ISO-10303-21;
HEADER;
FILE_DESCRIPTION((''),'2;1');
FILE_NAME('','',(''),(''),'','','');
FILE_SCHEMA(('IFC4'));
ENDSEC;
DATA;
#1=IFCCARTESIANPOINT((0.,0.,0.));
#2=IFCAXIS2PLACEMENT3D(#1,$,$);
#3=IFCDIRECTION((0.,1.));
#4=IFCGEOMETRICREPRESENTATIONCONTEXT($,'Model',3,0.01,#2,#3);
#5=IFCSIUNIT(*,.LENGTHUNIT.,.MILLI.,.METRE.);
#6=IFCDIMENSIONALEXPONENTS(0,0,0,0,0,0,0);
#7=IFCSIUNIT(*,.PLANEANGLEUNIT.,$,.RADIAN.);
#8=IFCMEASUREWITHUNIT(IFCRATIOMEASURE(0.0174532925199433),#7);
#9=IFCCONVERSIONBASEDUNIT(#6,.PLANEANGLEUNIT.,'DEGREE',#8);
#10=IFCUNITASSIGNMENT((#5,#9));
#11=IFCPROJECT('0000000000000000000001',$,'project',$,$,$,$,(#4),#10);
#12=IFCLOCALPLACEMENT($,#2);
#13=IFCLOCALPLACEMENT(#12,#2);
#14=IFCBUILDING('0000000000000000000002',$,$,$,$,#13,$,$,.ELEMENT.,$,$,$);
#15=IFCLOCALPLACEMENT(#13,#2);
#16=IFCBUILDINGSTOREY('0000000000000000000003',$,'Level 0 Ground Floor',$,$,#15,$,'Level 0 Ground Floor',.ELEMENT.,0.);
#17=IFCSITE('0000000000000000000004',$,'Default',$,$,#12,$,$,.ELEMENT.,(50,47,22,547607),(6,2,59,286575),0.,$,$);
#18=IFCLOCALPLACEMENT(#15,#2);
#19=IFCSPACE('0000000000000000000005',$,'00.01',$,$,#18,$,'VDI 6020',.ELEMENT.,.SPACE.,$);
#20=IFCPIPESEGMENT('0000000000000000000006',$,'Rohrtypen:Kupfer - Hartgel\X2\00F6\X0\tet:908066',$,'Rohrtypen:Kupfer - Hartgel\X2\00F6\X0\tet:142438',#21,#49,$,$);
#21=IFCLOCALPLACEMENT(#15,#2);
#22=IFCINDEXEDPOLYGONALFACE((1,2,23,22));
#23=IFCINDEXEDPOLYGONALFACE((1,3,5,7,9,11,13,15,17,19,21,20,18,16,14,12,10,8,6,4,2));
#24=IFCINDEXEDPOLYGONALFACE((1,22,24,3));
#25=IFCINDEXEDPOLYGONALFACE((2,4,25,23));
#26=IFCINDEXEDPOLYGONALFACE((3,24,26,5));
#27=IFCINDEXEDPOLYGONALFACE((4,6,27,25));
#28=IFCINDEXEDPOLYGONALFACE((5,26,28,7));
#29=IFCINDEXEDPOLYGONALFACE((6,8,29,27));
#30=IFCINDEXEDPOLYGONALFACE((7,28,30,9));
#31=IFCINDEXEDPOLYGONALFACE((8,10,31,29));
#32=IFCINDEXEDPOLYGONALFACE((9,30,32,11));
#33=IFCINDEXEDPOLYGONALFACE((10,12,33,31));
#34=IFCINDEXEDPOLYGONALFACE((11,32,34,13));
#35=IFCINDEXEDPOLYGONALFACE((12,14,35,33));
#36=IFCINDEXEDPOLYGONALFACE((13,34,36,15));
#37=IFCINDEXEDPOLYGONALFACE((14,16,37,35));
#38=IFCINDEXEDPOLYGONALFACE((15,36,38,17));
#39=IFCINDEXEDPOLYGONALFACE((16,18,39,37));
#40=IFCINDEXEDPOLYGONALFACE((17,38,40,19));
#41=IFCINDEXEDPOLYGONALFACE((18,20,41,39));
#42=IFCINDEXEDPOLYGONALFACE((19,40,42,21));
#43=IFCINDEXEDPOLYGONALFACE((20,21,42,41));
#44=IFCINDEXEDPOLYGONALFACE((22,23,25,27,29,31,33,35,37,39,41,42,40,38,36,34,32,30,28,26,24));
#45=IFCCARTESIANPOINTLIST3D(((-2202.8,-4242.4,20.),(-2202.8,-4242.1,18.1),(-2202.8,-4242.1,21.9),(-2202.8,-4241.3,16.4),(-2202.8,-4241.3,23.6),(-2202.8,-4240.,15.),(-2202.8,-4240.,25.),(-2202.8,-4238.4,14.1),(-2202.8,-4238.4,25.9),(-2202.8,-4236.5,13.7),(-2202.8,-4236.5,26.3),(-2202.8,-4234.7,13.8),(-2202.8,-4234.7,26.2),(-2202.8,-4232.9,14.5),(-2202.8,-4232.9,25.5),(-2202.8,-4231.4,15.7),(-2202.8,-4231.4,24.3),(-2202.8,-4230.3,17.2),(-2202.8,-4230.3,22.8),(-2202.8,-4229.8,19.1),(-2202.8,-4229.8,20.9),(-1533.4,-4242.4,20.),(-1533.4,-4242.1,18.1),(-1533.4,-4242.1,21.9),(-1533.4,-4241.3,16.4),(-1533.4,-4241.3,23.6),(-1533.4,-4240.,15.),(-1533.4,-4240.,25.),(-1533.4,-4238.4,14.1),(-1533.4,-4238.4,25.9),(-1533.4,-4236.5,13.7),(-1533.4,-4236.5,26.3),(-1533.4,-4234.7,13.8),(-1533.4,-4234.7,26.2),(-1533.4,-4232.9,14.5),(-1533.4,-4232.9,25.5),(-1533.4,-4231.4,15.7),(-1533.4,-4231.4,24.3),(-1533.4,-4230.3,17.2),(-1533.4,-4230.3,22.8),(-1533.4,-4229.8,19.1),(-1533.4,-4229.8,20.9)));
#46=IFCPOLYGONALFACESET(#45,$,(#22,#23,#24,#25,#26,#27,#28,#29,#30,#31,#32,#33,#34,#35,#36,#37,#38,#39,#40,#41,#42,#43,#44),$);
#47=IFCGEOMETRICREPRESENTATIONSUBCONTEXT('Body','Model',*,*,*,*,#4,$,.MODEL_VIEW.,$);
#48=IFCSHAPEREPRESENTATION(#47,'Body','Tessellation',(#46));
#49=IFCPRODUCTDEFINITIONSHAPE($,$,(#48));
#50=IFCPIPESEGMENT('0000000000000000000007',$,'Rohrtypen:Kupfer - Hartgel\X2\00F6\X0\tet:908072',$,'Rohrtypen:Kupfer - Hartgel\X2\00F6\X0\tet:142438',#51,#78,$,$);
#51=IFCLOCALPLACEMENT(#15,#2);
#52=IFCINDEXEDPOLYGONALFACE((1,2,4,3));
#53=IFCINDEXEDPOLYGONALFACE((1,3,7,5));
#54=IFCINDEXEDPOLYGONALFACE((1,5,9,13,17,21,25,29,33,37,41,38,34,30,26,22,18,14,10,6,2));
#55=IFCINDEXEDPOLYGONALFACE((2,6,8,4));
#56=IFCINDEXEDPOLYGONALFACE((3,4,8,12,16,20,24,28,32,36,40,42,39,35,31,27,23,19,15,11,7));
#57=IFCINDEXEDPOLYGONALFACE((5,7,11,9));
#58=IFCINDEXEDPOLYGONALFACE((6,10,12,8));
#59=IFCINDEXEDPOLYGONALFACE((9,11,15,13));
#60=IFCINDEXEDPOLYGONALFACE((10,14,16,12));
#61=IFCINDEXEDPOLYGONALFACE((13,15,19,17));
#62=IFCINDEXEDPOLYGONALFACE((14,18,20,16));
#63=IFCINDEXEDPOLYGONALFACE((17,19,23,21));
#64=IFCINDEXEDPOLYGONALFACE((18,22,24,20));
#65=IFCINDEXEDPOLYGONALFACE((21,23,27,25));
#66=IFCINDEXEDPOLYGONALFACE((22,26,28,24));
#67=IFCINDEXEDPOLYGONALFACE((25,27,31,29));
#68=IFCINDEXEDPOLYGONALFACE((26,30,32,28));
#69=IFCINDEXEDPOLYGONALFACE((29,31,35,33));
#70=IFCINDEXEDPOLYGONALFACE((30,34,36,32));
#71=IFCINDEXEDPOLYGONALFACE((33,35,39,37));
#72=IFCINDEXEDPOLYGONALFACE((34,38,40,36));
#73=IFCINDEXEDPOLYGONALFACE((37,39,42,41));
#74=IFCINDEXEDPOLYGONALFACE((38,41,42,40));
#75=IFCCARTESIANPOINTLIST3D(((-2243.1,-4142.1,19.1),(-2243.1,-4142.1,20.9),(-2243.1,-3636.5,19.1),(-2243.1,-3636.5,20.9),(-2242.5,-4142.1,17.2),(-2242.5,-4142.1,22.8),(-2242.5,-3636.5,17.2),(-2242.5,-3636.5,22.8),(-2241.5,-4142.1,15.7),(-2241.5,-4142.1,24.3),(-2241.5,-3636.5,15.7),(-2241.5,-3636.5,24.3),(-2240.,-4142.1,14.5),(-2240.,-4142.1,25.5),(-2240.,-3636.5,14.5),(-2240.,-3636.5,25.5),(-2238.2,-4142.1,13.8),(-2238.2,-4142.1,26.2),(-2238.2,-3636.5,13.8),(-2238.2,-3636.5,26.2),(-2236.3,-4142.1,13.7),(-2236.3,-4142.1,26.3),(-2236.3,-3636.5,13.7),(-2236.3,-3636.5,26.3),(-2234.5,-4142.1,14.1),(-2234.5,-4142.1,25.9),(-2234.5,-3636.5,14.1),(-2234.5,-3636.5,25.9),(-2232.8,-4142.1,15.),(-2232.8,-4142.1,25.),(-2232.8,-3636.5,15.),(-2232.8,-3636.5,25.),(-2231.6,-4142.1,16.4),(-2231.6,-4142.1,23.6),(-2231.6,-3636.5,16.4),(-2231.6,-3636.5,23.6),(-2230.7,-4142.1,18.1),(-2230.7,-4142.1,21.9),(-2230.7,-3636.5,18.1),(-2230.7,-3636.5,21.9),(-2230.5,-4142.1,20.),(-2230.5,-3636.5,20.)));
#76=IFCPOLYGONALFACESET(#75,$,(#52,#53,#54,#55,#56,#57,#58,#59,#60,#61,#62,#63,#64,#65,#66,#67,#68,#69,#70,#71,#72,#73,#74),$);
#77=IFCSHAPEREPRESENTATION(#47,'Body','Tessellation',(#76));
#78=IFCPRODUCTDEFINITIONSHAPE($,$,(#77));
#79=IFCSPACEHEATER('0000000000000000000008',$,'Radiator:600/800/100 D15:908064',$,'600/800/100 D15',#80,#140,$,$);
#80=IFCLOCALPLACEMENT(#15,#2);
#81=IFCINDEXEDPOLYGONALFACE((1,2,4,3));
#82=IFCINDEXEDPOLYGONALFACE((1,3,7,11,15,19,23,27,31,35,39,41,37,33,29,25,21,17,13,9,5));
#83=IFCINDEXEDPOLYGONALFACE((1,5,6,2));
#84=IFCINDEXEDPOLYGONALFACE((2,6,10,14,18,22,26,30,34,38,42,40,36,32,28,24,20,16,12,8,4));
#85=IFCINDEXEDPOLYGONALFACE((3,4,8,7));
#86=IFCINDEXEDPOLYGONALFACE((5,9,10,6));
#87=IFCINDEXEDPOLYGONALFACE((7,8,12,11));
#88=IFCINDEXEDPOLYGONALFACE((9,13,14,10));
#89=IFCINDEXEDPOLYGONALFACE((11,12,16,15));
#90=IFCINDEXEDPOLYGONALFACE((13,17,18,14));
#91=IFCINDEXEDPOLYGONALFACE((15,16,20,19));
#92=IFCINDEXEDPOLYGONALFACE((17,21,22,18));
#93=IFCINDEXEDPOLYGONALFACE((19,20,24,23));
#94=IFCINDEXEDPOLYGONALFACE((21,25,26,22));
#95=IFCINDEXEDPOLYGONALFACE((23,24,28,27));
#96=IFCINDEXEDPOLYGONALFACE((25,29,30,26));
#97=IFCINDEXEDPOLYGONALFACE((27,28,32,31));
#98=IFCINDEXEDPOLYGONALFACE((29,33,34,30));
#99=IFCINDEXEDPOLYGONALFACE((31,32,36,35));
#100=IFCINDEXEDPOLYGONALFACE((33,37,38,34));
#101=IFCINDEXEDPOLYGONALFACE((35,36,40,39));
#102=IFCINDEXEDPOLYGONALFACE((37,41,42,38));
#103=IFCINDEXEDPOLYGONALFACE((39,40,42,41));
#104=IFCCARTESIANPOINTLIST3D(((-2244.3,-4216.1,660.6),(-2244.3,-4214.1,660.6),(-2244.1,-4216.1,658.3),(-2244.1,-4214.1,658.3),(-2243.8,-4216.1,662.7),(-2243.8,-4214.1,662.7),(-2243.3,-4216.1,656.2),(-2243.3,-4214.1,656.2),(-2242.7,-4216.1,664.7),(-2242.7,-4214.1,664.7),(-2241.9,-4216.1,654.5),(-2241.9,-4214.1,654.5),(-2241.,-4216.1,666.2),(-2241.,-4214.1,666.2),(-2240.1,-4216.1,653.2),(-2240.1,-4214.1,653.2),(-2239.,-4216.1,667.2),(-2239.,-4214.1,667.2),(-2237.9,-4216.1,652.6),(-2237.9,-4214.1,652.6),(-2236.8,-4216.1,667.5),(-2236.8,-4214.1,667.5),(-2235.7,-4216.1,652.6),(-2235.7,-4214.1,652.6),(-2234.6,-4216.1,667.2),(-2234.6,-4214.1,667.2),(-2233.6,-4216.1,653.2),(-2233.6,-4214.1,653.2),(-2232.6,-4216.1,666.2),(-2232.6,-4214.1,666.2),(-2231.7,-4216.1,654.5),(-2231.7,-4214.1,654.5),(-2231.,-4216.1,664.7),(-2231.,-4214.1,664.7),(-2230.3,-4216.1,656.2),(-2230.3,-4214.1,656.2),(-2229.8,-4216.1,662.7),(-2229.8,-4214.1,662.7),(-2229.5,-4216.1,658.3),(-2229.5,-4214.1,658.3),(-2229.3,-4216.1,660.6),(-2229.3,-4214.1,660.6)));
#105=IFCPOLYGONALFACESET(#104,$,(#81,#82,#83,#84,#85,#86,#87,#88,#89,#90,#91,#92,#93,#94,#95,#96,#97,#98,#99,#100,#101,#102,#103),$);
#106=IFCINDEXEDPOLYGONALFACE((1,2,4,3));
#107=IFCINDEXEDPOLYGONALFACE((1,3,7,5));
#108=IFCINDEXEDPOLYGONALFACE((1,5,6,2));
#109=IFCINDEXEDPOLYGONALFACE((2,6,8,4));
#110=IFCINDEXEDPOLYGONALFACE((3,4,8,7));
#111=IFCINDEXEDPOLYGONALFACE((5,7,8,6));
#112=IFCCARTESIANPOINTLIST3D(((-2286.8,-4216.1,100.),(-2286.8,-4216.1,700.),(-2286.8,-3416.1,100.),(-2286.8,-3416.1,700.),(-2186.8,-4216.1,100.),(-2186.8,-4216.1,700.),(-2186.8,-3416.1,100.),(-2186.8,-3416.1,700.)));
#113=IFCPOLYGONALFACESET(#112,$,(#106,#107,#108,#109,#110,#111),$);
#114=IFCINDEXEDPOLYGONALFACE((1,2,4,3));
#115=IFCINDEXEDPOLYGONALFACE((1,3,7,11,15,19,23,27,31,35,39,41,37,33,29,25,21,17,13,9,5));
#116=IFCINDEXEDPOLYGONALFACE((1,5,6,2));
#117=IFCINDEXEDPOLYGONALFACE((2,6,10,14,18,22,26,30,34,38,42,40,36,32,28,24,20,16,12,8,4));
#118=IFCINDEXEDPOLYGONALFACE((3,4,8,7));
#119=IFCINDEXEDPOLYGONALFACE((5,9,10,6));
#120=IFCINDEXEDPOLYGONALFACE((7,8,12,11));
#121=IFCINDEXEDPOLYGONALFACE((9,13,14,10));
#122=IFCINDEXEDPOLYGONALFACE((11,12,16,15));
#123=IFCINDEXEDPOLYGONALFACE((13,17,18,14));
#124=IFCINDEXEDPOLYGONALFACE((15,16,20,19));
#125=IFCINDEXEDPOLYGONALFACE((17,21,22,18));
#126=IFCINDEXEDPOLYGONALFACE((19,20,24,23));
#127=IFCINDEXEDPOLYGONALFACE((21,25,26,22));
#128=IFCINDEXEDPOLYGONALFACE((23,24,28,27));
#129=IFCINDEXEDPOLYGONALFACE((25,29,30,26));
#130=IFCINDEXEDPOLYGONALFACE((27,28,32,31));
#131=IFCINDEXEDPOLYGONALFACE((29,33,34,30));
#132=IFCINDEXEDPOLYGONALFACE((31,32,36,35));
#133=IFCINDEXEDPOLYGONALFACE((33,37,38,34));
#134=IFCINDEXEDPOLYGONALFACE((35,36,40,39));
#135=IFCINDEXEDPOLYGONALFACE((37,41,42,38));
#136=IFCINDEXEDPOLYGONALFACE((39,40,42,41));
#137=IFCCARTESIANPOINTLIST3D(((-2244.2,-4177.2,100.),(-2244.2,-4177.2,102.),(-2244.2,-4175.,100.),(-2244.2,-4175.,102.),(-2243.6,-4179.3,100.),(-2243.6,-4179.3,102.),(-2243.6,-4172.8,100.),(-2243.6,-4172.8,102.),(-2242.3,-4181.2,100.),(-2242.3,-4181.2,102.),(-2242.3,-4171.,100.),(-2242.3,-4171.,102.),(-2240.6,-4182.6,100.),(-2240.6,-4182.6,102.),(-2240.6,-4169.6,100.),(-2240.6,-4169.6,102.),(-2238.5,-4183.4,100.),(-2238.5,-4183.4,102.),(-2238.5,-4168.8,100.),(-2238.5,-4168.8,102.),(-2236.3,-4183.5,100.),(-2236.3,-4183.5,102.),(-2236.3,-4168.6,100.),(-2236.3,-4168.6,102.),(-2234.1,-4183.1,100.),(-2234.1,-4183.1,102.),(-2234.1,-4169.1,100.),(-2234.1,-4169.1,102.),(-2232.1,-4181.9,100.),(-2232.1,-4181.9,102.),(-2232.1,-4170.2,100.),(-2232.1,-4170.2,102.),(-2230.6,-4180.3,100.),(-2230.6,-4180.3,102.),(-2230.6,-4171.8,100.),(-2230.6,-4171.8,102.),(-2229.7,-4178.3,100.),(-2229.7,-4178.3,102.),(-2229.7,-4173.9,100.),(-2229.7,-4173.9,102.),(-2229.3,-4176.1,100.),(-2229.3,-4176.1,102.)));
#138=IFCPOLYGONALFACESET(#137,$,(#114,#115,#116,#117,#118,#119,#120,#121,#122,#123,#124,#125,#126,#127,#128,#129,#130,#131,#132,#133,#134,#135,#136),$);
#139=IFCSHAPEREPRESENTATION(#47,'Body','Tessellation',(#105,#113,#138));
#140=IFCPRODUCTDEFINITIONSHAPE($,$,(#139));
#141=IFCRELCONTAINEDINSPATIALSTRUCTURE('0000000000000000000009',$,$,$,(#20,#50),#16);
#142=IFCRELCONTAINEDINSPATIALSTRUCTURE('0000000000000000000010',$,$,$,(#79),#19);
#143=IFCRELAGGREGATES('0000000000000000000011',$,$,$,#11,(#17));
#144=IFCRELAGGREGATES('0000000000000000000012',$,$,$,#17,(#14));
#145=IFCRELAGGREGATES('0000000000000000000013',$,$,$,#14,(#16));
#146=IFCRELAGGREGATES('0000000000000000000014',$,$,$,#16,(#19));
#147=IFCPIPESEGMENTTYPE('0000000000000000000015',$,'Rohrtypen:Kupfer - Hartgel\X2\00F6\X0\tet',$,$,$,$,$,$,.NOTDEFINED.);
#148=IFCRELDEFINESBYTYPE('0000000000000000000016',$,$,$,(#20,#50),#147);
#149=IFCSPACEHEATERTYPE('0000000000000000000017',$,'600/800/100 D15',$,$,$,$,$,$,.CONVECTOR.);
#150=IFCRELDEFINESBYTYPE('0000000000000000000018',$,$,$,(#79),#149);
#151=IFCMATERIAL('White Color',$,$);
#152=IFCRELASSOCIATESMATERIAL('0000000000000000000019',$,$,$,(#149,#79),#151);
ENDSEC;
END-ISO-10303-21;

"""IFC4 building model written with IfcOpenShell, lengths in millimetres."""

from ifc_helpers import new_model, entity, si_unit, converted_unit, direction, frame, frame_2d, origin, place, context, subcontext, project, spatial, rectangle, circle, extrude, source, transform, mapped, material, type_object, type_shapes, element, save


model = new_model("IFC4")

# Units and contexts
model_context = context("Model", 3, precision=0.01, world=origin(), true_north=direction((0.0, 1.0)))
body_context = subcontext(model_context, "Body", "Model", "MODEL_VIEW")
ifc_project = project(units=[si_unit("LENGTHUNIT", "METRE", prefix="MILLI"), converted_unit("PLANEANGLEUNIT", "DEGREE", entity("IfcRatioMeasure", 0.0174532925199433), si_unit("PLANEANGLEUNIT", "RADIAN"), dimensions=[0, 0, 0, 0, 0, 0, 0])], contexts=[model_context])

# Site, building, storey
site_placement = place(None, origin())
site = spatial("IfcSite", under=ifc_project, at=site_placement, Name="Default", CompositionType="ELEMENT", RefLatitude=(50, 47, 22, 547607), RefLongitude=(6, 2, 59, 286575), RefElevation=0.0)
building_placement = place(site_placement, origin())
building = spatial("IfcBuilding", under=site, at=building_placement, CompositionType="ELEMENT")
storey_placement = place(building_placement, origin())
storey = spatial("IfcBuildingStorey", under=building, at=storey_placement, Name="Level 0 Ground Floor", LongName="Level 0 Ground Floor", CompositionType="ELEMENT", Elevation=0.0)

# Pipe segments
pipe_segment_type = type_object("IfcPipeSegmentType", Name="Rohrtypen:Kupfer - Hartgelötet", PredefinedType="NOTDEFINED")
pipe_segment_1_placement = place(storey_placement, frame((-2202.8, -4244.0, 12.1)))
element("IfcPipeSegment", 1, at=pipe_segment_1_placement, inside=storey, type_object=pipe_segment_type, Name="Rohrtypen:Kupfer - Hartgelötet:908066", ObjectType="Rohrtypen:Kupfer - Hartgelötet:142438", context=body_context, shape_type="SweptSolid", body=[
    extrude(circle(Radius=6.3, at=frame_2d((0.0, 0.0), x_axis=(1.0, 0.0))), frame((0.0, 7.9, 7.9), z_axis=(1.0, 0.0, 0.0), x_axis=(0.0, -1.0, 0.0)), (0.0, 0.0, 1.0), 669.4),
])
pipe_segment_2_placement = place(storey_placement, frame((-2244.8, -4142.1, 12.1)))
element("IfcPipeSegment", 2, at=pipe_segment_2_placement, inside=storey, type_object=pipe_segment_type, Name="Rohrtypen:Kupfer - Hartgelötet:908072", ObjectType="Rohrtypen:Kupfer - Hartgelötet:142438", context=body_context, shape_type="SweptSolid", body=[
    extrude(circle(Radius=6.3, at=frame_2d((0.0, 0.0), x_axis=(1.0, 0.0))), frame((7.9, 0.0, 7.9), z_axis=(0.0, 1.0, 0.0), x_axis=(1.0, 0.0, 0.0)), (0.0, 0.0, 1.0), 505.5),
])

# Shared definitions
space_placement = place(storey_placement, origin())
space = spatial("IfcSpace", under=storey, at=space_placement, Name="00.01", LongName="VDI 6020", CompositionType="ELEMENT", PredefinedType="SPACE")

# Space heater
ifc_material_1 = material(Name="White Color")
space_heater_type = type_object("IfcSpaceHeaterType", Name="600/800/100 D15", PredefinedType="CONVECTOR", material=ifc_material_1)
shared_shape_1 = source(origin(), body_context, "Body", "SweptSolid", [
    extrude(circle(Radius=7.5, at=frame_2d((0.0, 0.0), x_axis=(1.0, 0.0))), frame((798.0, 50.0, 560.0), z_axis=(1.0, 0.0, 0.0), x_axis=(0.0, 0.0, 1.0)), (0.0, 0.0, 1.0), 2.0),
    extrude(rectangle(XDim=100.0, YDim=800.0, at=frame_2d((0.0, 0.0), x_axis=(1.0, 0.0))), frame((400.0, 50.0, 0.0), z_axis=(0.0, 0.0, 1.0), x_axis=(0.0, 1.0, 0.0)), (0.0, 0.0, 1.0), 600.0),
    extrude(circle(Radius=7.5, at=frame_2d((0.0, 0.0), x_axis=(1.0, 0.0))), frame((760.0, 50.0, 0.0), z_axis=(0.0, 0.0, 1.0), x_axis=(0.0, 1.0, 0.0)), (0.0, 0.0, 1.0), 2.0),
])
type_shapes(space_heater_type, [shared_shape_1])
space_heater_placement = place(space_placement, frame((-2286.8, -3416.1, 100.0), z_axis=(0.0, 0.0, 1.0), x_axis=(0.0, -1.0, 0.0)))
element("IfcSpaceHeater", 3, at=space_heater_placement, inside=space, type_object=space_heater_type, material=ifc_material_1, Name="Radiator:600/800/100 D15:908064", ObjectType="600/800/100 D15", context=body_context, shape_type="MappedRepresentation", body=[
    mapped(shared_shape_1, transform((0.0, 0.0, 0.0), scale=1.0)),
])

save(model, "model.ifc")
